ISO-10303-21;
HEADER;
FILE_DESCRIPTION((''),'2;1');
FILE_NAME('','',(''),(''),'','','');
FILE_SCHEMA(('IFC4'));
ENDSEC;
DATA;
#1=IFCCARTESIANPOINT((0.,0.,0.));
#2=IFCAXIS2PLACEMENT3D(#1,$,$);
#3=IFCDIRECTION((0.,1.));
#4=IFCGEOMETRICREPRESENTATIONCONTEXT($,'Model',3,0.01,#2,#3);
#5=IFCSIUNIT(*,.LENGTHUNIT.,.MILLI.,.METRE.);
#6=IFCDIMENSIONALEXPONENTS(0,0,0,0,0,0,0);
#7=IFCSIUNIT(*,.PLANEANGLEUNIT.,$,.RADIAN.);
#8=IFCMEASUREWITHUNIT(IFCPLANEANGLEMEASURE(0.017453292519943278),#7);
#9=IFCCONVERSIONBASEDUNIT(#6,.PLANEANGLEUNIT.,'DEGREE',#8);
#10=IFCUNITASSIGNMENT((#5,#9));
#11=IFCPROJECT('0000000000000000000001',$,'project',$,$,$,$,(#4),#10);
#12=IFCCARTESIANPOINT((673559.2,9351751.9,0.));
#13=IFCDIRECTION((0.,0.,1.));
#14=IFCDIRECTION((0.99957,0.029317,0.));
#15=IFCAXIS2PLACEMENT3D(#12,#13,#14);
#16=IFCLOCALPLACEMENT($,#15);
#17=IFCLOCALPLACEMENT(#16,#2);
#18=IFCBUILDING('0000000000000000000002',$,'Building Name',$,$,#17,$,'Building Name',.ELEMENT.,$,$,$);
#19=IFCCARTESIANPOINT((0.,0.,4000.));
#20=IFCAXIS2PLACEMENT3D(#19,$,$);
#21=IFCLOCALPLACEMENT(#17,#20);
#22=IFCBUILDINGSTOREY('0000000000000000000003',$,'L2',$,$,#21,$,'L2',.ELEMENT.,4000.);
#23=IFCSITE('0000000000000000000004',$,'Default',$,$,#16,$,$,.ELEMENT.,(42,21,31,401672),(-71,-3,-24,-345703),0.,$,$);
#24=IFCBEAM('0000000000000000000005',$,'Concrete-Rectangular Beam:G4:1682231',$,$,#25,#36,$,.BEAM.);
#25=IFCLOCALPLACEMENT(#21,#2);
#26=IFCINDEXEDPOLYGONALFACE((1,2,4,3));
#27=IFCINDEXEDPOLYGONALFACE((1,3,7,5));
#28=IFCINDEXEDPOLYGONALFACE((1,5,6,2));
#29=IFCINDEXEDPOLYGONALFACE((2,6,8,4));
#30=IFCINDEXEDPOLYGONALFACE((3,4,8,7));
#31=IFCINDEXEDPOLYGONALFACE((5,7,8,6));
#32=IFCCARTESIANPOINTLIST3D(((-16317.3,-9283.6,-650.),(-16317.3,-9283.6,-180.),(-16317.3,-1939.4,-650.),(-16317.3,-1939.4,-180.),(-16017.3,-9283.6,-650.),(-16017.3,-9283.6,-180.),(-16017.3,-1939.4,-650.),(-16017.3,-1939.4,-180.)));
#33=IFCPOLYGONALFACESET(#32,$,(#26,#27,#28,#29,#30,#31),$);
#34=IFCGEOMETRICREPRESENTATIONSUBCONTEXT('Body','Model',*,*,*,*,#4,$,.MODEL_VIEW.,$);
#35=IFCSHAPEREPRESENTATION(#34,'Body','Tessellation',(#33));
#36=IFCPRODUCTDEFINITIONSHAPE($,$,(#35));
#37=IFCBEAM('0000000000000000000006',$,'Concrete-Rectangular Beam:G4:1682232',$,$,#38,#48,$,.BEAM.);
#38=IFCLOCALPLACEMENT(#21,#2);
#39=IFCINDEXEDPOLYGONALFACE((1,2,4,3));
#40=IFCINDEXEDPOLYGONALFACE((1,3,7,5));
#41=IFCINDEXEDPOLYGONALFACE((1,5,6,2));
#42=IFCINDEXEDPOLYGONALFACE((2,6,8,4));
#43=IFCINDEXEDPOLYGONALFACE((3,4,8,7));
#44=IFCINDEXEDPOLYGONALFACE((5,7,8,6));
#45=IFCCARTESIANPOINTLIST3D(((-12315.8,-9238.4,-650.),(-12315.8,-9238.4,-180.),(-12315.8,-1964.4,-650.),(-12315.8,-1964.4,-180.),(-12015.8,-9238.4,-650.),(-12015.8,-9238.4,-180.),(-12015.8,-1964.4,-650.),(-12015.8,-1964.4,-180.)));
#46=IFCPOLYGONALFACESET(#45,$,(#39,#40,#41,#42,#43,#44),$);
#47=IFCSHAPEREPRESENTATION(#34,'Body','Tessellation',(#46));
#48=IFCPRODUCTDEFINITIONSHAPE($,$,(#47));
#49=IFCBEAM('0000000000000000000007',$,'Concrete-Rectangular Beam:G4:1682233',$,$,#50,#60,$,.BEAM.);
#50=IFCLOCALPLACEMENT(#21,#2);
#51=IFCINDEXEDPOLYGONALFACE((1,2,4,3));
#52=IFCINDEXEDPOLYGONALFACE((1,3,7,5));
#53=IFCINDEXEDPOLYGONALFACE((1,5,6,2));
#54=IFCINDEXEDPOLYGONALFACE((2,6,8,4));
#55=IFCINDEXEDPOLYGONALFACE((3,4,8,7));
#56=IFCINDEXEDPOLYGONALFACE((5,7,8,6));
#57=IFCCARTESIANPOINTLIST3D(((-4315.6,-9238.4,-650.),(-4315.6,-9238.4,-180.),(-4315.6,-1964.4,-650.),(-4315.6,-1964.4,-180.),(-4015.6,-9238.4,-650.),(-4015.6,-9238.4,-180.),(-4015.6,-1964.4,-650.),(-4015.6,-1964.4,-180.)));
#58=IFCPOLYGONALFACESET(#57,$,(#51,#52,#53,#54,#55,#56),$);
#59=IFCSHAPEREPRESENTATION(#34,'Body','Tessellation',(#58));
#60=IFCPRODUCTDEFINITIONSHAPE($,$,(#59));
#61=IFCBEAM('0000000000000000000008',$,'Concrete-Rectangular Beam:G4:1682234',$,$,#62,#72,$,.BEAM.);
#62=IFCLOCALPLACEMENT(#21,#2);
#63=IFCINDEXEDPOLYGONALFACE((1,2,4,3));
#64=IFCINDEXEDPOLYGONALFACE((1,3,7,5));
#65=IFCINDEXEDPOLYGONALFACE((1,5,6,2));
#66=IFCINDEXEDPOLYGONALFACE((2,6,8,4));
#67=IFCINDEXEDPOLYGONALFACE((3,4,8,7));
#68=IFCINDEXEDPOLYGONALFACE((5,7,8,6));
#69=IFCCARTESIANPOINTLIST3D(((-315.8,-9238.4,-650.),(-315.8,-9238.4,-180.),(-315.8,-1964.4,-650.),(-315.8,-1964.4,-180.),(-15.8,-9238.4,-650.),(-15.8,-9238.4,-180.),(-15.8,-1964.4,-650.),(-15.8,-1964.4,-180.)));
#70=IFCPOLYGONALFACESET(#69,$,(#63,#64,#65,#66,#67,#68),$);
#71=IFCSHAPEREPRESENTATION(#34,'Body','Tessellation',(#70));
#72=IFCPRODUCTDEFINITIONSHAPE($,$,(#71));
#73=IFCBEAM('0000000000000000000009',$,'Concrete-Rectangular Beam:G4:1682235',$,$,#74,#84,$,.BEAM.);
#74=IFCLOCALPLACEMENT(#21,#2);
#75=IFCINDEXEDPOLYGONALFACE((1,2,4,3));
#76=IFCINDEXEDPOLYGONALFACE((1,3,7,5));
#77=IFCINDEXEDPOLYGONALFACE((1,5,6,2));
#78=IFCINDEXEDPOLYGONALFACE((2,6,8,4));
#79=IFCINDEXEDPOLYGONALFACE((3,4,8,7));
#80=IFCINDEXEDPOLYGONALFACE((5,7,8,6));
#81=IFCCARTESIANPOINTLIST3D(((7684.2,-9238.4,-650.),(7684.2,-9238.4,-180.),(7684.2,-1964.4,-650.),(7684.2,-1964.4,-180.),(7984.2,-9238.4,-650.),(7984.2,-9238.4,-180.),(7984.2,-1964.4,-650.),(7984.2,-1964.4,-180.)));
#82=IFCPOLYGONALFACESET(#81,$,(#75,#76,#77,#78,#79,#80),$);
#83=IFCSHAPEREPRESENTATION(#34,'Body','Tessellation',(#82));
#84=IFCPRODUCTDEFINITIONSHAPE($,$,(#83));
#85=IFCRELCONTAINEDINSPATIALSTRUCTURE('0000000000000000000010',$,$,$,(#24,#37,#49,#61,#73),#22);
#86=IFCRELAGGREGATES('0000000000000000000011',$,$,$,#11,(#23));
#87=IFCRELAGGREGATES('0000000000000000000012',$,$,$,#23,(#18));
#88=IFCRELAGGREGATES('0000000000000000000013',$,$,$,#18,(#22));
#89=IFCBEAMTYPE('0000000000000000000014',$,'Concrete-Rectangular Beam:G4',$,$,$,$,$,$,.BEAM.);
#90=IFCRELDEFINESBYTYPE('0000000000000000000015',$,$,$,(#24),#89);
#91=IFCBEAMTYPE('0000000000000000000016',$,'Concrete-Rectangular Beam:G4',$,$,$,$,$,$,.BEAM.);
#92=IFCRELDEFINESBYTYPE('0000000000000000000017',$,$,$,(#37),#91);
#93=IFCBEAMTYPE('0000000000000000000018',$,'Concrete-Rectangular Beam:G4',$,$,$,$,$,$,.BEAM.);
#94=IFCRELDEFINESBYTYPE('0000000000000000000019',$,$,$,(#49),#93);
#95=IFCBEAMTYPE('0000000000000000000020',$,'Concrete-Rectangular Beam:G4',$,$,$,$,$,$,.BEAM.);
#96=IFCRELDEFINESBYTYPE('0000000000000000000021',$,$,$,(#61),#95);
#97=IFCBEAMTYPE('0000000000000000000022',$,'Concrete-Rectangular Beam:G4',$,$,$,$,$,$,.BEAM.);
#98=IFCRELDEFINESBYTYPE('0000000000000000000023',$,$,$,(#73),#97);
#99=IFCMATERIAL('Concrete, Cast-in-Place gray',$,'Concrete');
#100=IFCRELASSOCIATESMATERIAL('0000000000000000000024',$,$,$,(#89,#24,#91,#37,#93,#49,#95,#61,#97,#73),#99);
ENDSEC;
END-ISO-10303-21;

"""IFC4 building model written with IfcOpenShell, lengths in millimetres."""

from ifc_helpers import new_model, entity, si_unit, converted_unit, direction, frame, origin, place, context, subcontext, project, spatial, indexed_curve, outline, extrude, source, transform, mapped, material, type_object, type_shapes, element, save


model = new_model("IFC4")

# Units and contexts
model_context = context("Model", 3, precision=0.01, world=origin(), true_north=direction((0.0, 1.0)))
body_context = subcontext(model_context, "Body", "Model", "MODEL_VIEW")
ifc_project = project(units=[si_unit("LENGTHUNIT", "METRE", prefix="MILLI"), converted_unit("PLANEANGLEUNIT", "DEGREE", entity("IfcPlaneAngleMeasure", 0.017453292519943278), si_unit("PLANEANGLEUNIT", "RADIAN"), dimensions=[0, 0, 0, 0, 0, 0, 0])], contexts=[model_context])

# Site, building, storey
site_placement = place(None, frame((673559.2, 9351751.9, 0.0), z_axis=(0.0, 0.0, 1.0), x_axis=(0.99957, 0.029317, 0.0)))
site = spatial("IfcSite", under=ifc_project, at=site_placement, Name="Default", CompositionType="ELEMENT", RefLatitude=(42, 21, 31, 401672), RefLongitude=(-71, -3, -24, -345703), RefElevation=0.0)
building_placement = place(site_placement, origin())
building = spatial("IfcBuilding", under=site, at=building_placement, Name="Building Name", LongName="Building Name", CompositionType="ELEMENT")
storey_placement = place(building_placement, frame((0.0, 0.0, 4000.0)))
storey = spatial("IfcBuildingStorey", under=building, at=storey_placement, Name="L2", LongName="L2", CompositionType="ELEMENT", Elevation=4000.0)

# Beams
ifc_material = material(Name="Concrete, Cast-in-Place gray", Category="Concrete")
beam_type_1 = type_object("IfcBeamType", Name="Concrete-Rectangular Beam:G4", PredefinedType="BEAM", material=ifc_material)
shared_shape_1 = source(origin(), body_context, "Body", "SweptSolid", [
    extrude(outline(indexed_curve([(-150.0, -235.0), (150.0, -235.0), (150.0, 235.0), (-150.0, 235.0), (-150.0, -235.0)], self_intersect=False)), frame((-16167.3, -9283.6, 3585.0), z_axis=(0.0, 1.0, 0.0), x_axis=(-1.0, 0.0, 0.0)), (0.0, 0.0, 1.0), 7344.1),
])
type_shapes(beam_type_1, [shared_shape_1])
beam_1_placement = place(storey_placement, frame((0.0, 0.0, -4000.0)))
element("IfcBeam", 1, at=beam_1_placement, inside=storey, type_object=beam_type_1, material=ifc_material, Name="Concrete-Rectangular Beam:G4:1682231", PredefinedType="BEAM", context=body_context, shape_type="MappedRepresentation", body=[
    mapped(shared_shape_1, transform((0.0, 0.0, 0.0), scale=1.0)),
])
beam_type_2 = type_object("IfcBeamType", Name="Concrete-Rectangular Beam:G4", PredefinedType="BEAM", material=ifc_material)
shared_shape_2 = source(origin(), body_context, "Body", "SweptSolid", [
    extrude(outline(indexed_curve([(-150.0, -235.0), (150.0, -235.0), (150.0, 235.0), (-150.0, 235.0), (-150.0, -235.0)], self_intersect=False)), frame((-12165.8, -9238.4, 3585.0), z_axis=(0.0, 1.0, 0.0), x_axis=(-1.0, 0.0, 0.0)), (0.0, 0.0, 1.0), 7273.9),
])
type_shapes(beam_type_2, [shared_shape_2])
beam_2_placement = place(storey_placement, frame((0.0, 0.0, -4000.0)))
element("IfcBeam", 2, at=beam_2_placement, inside=storey, type_object=beam_type_2, material=ifc_material, Name="Concrete-Rectangular Beam:G4:1682232", PredefinedType="BEAM", context=body_context, shape_type="MappedRepresentation", body=[
    mapped(shared_shape_2, transform((0.0, 0.0, 0.0), scale=1.0)),
])
beam_type_3 = type_object("IfcBeamType", Name="Concrete-Rectangular Beam:G4", PredefinedType="BEAM", material=ifc_material)
shared_shape_3 = source(origin(), body_context, "Body", "SweptSolid", [
    extrude(outline(indexed_curve([(-150.0, -235.0), (150.0, -235.0), (150.0, 235.0), (-150.0, 235.0), (-150.0, -235.0)], self_intersect=False)), frame((-4165.6, -9238.4, 3585.0), z_axis=(0.0, 1.0, 0.0), x_axis=(-1.0, 0.0, 0.0)), (0.0, 0.0, 1.0), 7273.9),
])
type_shapes(beam_type_3, [shared_shape_3])
beam_3_placement = place(storey_placement, frame((0.0, 0.0, -4000.0)))
element("IfcBeam", 3, at=beam_3_placement, inside=storey, type_object=beam_type_3, material=ifc_material, Name="Concrete-Rectangular Beam:G4:1682233", PredefinedType="BEAM", context=body_context, shape_type="MappedRepresentation", body=[
    mapped(shared_shape_3, transform((0.0, 0.0, 0.0), scale=1.0)),
])
beam_type_4 = type_object("IfcBeamType", Name="Concrete-Rectangular Beam:G4", PredefinedType="BEAM", material=ifc_material)
shared_shape_4 = source(origin(), body_context, "Body", "SweptSolid", [
    extrude(outline(indexed_curve([(-150.0, -235.0), (150.0, -235.0), (150.0, 235.0), (-150.0, 235.0), (-150.0, -235.0)], self_intersect=False)), frame((-165.8, -9238.4, 3585.0), z_axis=(0.0, 1.0, 0.0), x_axis=(-1.0, 0.0, 0.0)), (0.0, 0.0, 1.0), 7273.9),
])
type_shapes(beam_type_4, [shared_shape_4])
beam_4_placement = place(storey_placement, frame((0.0, 0.0, -4000.0)))
element("IfcBeam", 4, at=beam_4_placement, inside=storey, type_object=beam_type_4, material=ifc_material, Name="Concrete-Rectangular Beam:G4:1682234", PredefinedType="BEAM", context=body_context, shape_type="MappedRepresentation", body=[
    mapped(shared_shape_4, transform((0.0, 0.0, 0.0), scale=1.0)),
])
beam_type_5 = type_object("IfcBeamType", Name="Concrete-Rectangular Beam:G4", PredefinedType="BEAM", material=ifc_material)
shared_shape_5 = source(origin(), body_context, "Body", "SweptSolid", [
    extrude(outline(indexed_curve([(-150.0, -235.0), (150.0, -235.0), (150.0, 235.0), (-150.0, 235.0), (-150.0, -235.0)], self_intersect=False)), frame((7834.2, -9238.4, 3585.0), z_axis=(0.0, 1.0, 0.0), x_axis=(-1.0, 0.0, 0.0)), (0.0, 0.0, 1.0), 7273.9),
])
type_shapes(beam_type_5, [shared_shape_5])
beam_5_placement = place(storey_placement, frame((0.0, 0.0, -4000.0)))
element("IfcBeam", 5, at=beam_5_placement, inside=storey, type_object=beam_type_5, material=ifc_material, Name="Concrete-Rectangular Beam:G4:1682235", PredefinedType="BEAM", context=body_context, shape_type="MappedRepresentation", body=[
    mapped(shared_shape_5, transform((0.0, 0.0, 0.0), scale=1.0)),
])

save(model, "model.ifc")
